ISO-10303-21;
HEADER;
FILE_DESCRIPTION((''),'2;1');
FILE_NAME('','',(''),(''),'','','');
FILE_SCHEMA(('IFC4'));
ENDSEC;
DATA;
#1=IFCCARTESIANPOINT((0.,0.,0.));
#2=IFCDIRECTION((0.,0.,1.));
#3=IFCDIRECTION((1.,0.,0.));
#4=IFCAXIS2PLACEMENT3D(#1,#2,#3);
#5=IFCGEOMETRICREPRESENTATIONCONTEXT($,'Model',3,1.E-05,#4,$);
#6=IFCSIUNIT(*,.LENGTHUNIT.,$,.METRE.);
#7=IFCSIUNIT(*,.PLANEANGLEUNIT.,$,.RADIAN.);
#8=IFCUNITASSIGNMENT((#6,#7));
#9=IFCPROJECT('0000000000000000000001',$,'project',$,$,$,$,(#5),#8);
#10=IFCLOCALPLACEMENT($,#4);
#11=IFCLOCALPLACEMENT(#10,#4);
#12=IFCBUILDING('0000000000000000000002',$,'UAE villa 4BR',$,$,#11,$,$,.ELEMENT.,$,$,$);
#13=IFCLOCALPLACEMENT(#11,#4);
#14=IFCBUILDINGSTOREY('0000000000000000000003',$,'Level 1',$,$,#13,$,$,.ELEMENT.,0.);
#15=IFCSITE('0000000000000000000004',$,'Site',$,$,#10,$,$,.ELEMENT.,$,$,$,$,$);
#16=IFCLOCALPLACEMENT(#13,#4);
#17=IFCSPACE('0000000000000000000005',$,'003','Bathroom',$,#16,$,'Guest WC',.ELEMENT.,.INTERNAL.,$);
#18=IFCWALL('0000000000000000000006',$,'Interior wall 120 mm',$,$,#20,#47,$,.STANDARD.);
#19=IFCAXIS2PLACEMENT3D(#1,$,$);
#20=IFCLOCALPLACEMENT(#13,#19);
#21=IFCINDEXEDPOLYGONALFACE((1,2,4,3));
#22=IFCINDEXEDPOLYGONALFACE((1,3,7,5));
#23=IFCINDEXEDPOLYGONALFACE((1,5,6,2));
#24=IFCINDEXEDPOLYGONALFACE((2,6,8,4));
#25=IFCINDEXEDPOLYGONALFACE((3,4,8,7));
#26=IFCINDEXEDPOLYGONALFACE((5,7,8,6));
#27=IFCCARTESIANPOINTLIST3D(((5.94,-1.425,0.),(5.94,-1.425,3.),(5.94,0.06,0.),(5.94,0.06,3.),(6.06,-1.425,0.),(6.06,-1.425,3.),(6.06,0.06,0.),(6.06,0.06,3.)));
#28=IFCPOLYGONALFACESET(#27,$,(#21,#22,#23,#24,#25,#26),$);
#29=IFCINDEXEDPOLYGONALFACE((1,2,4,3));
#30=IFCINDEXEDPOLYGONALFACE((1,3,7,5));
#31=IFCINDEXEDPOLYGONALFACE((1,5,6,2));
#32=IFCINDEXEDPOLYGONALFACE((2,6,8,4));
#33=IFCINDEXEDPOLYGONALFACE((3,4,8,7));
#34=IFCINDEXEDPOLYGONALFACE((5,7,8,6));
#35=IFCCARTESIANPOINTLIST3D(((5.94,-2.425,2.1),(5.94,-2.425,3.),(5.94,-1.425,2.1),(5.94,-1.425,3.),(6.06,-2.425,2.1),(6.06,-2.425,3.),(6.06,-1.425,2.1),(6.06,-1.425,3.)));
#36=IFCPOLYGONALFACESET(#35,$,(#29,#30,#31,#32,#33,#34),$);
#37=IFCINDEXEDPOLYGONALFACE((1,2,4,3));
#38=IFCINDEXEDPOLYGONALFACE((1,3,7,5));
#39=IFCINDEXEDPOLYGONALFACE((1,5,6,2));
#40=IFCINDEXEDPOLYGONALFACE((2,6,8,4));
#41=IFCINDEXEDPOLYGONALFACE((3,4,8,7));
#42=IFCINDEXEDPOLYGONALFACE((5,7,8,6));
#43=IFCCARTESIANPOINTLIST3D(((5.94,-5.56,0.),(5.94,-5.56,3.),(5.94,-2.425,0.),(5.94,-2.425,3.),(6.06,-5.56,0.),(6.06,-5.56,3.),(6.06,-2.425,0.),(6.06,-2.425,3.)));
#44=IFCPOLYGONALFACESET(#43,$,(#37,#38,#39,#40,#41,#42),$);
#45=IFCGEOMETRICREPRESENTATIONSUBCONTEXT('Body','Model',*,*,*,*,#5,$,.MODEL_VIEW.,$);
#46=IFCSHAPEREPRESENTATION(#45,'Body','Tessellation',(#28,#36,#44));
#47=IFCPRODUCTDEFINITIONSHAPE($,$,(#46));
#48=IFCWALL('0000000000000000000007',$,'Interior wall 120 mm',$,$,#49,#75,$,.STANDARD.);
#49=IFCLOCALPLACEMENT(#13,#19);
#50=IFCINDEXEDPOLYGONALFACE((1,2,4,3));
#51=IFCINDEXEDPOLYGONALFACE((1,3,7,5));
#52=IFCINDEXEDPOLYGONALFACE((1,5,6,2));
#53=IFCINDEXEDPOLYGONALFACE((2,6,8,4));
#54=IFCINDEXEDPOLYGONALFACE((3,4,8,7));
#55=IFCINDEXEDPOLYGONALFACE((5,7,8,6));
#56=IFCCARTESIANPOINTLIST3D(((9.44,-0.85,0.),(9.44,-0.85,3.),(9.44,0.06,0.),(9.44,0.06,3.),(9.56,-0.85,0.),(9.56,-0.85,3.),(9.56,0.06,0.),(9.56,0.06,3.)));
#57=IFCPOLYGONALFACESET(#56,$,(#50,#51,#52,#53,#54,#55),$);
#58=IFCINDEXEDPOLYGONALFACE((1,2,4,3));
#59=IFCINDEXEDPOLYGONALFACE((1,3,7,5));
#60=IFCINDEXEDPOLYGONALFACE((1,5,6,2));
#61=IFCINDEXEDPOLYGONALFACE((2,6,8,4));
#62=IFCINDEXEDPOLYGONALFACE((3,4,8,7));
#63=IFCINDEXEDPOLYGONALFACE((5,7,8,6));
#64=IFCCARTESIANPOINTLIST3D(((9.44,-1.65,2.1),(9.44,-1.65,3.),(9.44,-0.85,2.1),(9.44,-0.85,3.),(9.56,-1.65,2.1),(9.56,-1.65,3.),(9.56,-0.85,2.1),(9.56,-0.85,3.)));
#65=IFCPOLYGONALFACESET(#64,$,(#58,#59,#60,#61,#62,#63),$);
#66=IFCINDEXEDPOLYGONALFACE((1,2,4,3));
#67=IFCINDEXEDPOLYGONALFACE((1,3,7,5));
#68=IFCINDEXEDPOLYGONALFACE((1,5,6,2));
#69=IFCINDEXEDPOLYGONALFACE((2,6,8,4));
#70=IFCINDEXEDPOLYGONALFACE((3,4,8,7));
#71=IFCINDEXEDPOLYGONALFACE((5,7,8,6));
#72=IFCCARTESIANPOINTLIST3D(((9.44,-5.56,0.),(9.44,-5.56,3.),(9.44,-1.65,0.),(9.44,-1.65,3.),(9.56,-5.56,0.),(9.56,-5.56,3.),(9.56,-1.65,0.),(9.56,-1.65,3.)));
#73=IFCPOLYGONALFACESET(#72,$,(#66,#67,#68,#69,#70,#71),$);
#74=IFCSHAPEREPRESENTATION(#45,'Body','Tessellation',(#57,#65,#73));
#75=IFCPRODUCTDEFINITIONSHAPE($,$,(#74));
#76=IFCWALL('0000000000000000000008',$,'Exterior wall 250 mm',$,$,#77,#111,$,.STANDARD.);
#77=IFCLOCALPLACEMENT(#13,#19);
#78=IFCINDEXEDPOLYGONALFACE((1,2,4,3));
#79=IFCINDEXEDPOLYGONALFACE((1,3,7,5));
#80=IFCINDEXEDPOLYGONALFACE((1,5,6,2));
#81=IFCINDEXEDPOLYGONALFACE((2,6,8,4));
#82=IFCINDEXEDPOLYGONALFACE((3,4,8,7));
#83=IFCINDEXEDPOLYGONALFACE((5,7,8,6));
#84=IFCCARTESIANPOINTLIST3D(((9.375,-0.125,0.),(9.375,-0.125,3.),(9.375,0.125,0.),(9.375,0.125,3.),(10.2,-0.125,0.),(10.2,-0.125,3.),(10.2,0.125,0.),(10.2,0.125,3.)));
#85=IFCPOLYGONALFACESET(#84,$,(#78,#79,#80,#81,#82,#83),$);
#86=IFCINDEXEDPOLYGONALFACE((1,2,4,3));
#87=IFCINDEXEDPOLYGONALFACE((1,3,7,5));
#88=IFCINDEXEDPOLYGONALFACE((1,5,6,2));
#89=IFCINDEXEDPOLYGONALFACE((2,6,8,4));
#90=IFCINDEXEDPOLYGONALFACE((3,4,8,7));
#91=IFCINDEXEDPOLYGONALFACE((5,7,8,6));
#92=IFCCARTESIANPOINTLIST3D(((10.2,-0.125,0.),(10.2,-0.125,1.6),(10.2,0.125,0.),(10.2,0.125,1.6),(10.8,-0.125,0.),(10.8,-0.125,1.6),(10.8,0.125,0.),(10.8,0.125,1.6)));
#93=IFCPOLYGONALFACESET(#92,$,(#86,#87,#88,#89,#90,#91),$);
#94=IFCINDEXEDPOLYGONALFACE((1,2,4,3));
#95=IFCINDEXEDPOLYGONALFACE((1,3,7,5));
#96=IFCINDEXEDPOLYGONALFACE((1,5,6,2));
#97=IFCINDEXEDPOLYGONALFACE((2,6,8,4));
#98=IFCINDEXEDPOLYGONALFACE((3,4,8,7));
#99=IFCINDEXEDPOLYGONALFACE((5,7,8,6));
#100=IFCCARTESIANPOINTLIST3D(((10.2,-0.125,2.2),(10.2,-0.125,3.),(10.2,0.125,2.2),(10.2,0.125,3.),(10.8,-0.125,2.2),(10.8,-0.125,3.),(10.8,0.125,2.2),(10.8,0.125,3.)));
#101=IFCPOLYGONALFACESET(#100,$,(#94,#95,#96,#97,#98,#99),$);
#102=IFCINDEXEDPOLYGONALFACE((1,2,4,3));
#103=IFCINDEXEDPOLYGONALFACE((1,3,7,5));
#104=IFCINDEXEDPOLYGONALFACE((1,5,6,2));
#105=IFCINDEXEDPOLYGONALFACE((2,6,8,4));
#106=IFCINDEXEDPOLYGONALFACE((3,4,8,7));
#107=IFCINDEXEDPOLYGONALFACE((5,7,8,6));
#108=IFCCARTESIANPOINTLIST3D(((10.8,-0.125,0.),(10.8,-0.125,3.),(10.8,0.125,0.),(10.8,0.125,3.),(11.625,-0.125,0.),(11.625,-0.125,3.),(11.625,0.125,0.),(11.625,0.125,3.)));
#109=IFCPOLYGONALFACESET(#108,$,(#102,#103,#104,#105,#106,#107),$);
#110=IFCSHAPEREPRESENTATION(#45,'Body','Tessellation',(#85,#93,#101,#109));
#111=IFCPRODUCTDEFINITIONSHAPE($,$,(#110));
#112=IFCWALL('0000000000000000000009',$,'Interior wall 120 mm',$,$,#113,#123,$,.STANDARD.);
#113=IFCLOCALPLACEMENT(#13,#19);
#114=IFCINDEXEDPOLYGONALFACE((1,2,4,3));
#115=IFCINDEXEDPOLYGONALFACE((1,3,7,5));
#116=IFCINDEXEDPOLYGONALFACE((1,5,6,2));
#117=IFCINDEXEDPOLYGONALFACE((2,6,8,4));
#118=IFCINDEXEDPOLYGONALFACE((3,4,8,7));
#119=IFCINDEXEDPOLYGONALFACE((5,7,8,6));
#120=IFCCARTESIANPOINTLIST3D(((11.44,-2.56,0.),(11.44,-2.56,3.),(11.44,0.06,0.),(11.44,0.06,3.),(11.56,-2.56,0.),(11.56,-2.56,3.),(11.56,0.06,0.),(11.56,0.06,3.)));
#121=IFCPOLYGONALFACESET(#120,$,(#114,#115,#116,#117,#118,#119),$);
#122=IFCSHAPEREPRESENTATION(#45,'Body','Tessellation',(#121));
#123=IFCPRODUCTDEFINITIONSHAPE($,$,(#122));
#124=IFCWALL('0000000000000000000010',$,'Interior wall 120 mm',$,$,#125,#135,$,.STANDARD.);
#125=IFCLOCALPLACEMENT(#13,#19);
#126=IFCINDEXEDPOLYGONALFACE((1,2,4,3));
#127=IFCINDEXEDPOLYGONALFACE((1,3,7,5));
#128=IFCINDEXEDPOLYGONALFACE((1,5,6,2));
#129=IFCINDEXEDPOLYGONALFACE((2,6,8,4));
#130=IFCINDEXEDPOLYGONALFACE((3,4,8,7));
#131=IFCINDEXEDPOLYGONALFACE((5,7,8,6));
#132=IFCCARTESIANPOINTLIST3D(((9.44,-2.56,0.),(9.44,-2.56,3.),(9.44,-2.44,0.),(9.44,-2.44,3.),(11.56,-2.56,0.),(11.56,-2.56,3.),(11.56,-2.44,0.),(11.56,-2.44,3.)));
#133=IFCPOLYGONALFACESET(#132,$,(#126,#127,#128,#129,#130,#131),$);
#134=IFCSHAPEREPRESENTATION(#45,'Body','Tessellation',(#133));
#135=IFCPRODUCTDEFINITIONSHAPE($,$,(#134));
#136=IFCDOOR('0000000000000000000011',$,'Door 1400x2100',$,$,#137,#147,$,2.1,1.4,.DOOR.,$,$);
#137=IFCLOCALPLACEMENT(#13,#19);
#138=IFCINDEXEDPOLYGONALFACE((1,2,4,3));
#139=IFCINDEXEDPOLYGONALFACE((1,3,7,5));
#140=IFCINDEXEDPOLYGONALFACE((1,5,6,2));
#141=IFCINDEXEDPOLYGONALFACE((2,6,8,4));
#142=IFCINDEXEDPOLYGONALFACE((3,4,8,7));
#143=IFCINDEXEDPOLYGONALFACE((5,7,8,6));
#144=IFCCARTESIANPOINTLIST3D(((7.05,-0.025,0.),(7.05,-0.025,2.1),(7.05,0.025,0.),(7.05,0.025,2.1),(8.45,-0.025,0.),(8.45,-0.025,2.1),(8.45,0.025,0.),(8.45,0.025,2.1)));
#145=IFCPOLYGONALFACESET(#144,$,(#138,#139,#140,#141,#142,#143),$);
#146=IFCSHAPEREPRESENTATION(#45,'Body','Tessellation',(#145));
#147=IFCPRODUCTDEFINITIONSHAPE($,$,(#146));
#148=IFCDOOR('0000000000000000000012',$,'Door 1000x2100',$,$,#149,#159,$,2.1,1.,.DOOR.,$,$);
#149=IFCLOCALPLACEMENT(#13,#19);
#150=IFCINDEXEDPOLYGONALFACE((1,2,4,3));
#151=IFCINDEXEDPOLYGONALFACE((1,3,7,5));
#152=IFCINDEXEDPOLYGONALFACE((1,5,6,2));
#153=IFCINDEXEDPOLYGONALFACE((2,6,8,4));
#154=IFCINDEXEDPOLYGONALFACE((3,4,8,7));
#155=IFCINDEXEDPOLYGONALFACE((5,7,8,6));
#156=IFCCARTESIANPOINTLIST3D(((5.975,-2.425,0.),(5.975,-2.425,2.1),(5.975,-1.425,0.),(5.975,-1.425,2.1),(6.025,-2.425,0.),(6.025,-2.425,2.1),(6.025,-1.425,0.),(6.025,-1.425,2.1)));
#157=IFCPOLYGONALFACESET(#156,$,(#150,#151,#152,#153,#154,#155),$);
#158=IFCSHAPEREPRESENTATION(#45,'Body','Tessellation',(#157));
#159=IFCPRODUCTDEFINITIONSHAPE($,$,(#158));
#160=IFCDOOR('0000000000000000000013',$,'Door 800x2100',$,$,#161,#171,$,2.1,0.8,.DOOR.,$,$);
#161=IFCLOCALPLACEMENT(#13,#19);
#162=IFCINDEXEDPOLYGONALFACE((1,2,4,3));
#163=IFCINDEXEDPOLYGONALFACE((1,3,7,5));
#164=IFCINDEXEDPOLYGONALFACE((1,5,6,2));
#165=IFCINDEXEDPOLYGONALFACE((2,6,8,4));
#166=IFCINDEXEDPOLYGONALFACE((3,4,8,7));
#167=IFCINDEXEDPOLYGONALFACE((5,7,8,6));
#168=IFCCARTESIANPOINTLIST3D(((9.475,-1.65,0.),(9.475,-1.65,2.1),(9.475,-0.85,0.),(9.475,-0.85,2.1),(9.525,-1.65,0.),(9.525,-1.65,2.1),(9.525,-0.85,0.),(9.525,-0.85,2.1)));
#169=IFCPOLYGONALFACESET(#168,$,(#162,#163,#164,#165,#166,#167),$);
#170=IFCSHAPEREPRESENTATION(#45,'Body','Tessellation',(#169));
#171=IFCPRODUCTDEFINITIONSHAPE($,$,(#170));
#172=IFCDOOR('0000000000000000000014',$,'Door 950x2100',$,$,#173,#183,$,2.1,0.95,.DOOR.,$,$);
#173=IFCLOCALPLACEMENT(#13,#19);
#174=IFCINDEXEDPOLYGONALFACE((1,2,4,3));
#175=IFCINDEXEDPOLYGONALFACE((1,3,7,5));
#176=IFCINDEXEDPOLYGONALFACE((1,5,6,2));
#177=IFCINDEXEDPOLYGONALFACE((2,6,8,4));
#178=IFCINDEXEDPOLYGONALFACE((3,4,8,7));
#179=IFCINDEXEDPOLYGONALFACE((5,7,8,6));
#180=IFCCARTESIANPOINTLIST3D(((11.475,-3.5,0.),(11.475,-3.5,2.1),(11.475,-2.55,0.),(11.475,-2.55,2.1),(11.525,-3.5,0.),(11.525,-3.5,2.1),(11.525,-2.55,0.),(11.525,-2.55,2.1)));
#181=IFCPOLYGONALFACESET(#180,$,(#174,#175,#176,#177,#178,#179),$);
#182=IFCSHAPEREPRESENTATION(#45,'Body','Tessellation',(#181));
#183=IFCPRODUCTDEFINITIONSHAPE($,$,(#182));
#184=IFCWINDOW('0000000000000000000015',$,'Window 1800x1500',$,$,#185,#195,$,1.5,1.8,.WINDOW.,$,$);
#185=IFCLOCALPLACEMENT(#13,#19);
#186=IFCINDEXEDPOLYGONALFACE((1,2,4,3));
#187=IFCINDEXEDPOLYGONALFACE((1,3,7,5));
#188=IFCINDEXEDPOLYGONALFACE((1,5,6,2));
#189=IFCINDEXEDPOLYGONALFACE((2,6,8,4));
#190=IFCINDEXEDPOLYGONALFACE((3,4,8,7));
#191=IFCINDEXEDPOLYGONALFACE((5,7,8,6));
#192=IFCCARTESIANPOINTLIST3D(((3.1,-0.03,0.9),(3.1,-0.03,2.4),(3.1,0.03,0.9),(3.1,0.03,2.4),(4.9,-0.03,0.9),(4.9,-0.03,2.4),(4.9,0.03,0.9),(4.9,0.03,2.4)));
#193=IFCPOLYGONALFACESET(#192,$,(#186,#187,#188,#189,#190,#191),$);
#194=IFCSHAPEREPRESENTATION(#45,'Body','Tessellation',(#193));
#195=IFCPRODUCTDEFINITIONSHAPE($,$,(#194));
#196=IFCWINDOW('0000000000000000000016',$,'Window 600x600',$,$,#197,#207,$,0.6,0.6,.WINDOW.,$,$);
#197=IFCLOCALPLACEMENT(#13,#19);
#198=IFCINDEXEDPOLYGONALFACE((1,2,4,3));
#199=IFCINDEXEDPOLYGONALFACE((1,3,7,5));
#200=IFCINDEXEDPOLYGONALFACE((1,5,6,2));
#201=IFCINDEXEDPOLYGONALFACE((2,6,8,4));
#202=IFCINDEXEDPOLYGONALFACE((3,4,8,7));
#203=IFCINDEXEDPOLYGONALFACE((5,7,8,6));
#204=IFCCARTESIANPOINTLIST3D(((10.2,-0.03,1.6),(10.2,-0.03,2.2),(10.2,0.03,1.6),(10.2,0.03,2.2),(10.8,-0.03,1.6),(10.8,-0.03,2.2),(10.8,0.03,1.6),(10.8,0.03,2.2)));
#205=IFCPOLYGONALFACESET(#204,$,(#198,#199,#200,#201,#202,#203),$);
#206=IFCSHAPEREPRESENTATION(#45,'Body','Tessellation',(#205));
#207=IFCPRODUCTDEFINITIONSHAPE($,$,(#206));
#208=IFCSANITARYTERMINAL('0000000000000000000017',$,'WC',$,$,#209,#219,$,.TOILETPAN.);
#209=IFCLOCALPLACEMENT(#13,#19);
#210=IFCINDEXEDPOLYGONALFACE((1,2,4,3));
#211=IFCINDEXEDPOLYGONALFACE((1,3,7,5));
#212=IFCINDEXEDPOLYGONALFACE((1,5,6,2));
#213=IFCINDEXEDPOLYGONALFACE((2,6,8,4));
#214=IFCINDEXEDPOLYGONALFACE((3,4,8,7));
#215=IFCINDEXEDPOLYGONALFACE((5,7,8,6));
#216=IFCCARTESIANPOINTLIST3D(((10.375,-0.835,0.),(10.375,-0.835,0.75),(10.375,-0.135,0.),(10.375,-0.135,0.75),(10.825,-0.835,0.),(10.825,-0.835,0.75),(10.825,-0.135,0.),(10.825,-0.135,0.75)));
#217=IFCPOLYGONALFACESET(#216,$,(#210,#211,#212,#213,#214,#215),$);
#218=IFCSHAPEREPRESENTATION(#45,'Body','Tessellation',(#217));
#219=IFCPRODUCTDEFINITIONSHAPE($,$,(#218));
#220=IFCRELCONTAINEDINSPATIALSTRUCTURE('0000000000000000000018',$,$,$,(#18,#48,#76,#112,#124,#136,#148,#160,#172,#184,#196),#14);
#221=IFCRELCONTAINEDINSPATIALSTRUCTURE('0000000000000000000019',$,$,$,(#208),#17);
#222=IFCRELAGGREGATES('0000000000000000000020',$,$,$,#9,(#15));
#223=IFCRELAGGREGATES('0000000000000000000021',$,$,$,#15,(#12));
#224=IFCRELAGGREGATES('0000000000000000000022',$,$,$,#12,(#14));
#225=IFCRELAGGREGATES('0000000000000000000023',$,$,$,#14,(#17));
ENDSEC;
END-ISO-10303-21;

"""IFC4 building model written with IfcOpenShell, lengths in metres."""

from ifc_helpers import new_model, si_unit, frame, origin, origin_with_axes, origin_2d, place, context, subcontext, project, spatial, rectangle, extrude, element, save


model = new_model("IFC4")

# Units and contexts
model_context = context("Model", 3, precision=1e-05, world=origin_with_axes())
body_context = subcontext(model_context, "Body", "Model", "MODEL_VIEW")
ifc_project = project(units=[si_unit("LENGTHUNIT", "METRE"), si_unit("PLANEANGLEUNIT", "RADIAN")], contexts=[model_context])

# Site, building, storey
site_placement = place(None, origin_with_axes())
site = spatial("IfcSite", under=ifc_project, at=site_placement, Name="Site", CompositionType="ELEMENT")
building_placement = place(site_placement, origin_with_axes())
building = spatial("IfcBuilding", under=site, at=building_placement, Name="UAE villa 4BR", CompositionType="ELEMENT")
storey_placement = place(building_placement, origin_with_axes())
storey = spatial("IfcBuildingStorey", under=building, at=storey_placement, Name="Level 1", CompositionType="ELEMENT", Elevation=0.0)

# Walls
wall_1_placement = place(storey_placement, frame((6.0, 0.0, 0.0), z_axis=(0.0, 0.0, 1.0), x_axis=(0.0, -1.0, 0.0)))
element("IfcWall", 1, at=wall_1_placement, inside=storey, Name="Interior wall 120 mm", PredefinedType="STANDARD", context=body_context, shape_type="SweptSolid", body=[
    extrude(rectangle(XDim=1.485, YDim=0.12, at=origin_2d()), frame((0.6825, 0.0, 0.0)), (0.0, 0.0, 1.0), 3.0),
    extrude(rectangle(XDim=1.0, YDim=0.12, at=origin_2d()), frame((1.925, 0.0, 2.1)), (0.0, 0.0, 1.0), 0.9),
    extrude(rectangle(XDim=3.135, YDim=0.12, at=origin_2d()), frame((3.9925, 0.0, 0.0)), (0.0, 0.0, 1.0), 3.0),
])
wall_2_placement = place(storey_placement, frame((9.5, 0.0, 0.0), z_axis=(0.0, 0.0, 1.0), x_axis=(0.0, -1.0, 0.0)))
element("IfcWall", 2, at=wall_2_placement, inside=storey, Name="Interior wall 120 mm", PredefinedType="STANDARD", context=body_context, shape_type="SweptSolid", body=[
    extrude(rectangle(XDim=0.91, YDim=0.12, at=origin_2d()), frame((0.395, 0.0, 0.0)), (0.0, 0.0, 1.0), 3.0),
    extrude(rectangle(XDim=0.8, YDim=0.12, at=origin_2d()), frame((1.25, 0.0, 2.1)), (0.0, 0.0, 1.0), 0.9),
    extrude(rectangle(XDim=3.91, YDim=0.12, at=origin_2d()), frame((3.605, 0.0, 0.0)), (0.0, 0.0, 1.0), 3.0),
])
wall_3_placement = place(storey_placement, frame((9.5, 0.0, 0.0), z_axis=(0.0, 0.0, 1.0), x_axis=(1.0, 0.0, 0.0)))
element("IfcWall", 3, at=wall_3_placement, inside=storey, Name="Exterior wall 250 mm", PredefinedType="STANDARD", context=body_context, shape_type="SweptSolid", body=[
    extrude(rectangle(XDim=0.825, YDim=0.25, at=origin_2d()), frame((0.2875, 0.0, 0.0)), (0.0, 0.0, 1.0), 3.0),
    extrude(rectangle(XDim=0.6, YDim=0.25, at=origin_2d()), frame((1.0, 0.0, 0.0)), (0.0, 0.0, 1.0), 1.6),
    extrude(rectangle(XDim=0.6, YDim=0.25, at=origin_2d()), frame((1.0, 0.0, 2.2)), (0.0, 0.0, 1.0), 0.8),
    extrude(rectangle(XDim=0.825, YDim=0.25, at=origin_2d()), frame((1.7125, 0.0, 0.0)), (0.0, 0.0, 1.0), 3.0),
])
wall_4_placement = place(storey_placement, frame((11.5, 0.0, 0.0), z_axis=(0.0, 0.0, 1.0), x_axis=(0.0, -1.0, 0.0)))
element("IfcWall", 4, at=wall_4_placement, inside=storey, Name="Interior wall 120 mm", PredefinedType="STANDARD", context=body_context, shape_type="SweptSolid", body=[
    extrude(rectangle(XDim=2.62, YDim=0.12, at=origin_2d()), frame((1.25, 0.0, 0.0)), (0.0, 0.0, 1.0), 3.0),
])
wall_5_placement = place(storey_placement, frame((11.5, -2.5, 0.0), z_axis=(0.0, 0.0, 1.0), x_axis=(-1.0, 0.0, 0.0)))
element("IfcWall", 5, at=wall_5_placement, inside=storey, Name="Interior wall 120 mm", PredefinedType="STANDARD", context=body_context, shape_type="SweptSolid", body=[
    extrude(rectangle(XDim=2.12, YDim=0.12, at=origin_2d()), frame((1.0, 0.0, 0.0)), (0.0, 0.0, 1.0), 3.0),
])

# Doors
door_1_placement = place(storey_placement, frame((7.75, 0.0, 0.0), z_axis=(0.0, 0.0, 1.0), x_axis=(1.0, 0.0, 0.0)))
element("IfcDoor", 6, at=door_1_placement, inside=storey, Name="Door 1400x2100", OverallHeight=2.1, OverallWidth=1.4, PredefinedType="DOOR", context=body_context, shape_type="SweptSolid", body=[
    extrude(rectangle(XDim=1.4, YDim=0.05, at=origin_2d()), origin(), (0.0, 0.0, 1.0), 2.1),
])
door_2_placement = place(storey_placement, frame((6.0, -1.925, 0.0), z_axis=(0.0, 0.0, 1.0), x_axis=(0.0, -1.0, 0.0)))
element("IfcDoor", 7, at=door_2_placement, inside=storey, Name="Door 1000x2100", OverallHeight=2.1, OverallWidth=1.0, PredefinedType="DOOR", context=body_context, shape_type="SweptSolid", body=[
    extrude(rectangle(XDim=1.0, YDim=0.05, at=origin_2d()), origin(), (0.0, 0.0, 1.0), 2.1),
])
door_3_placement = place(storey_placement, frame((9.5, -1.25, 0.0), z_axis=(0.0, 0.0, 1.0), x_axis=(0.0, -1.0, 0.0)))
element("IfcDoor", 8, at=door_3_placement, inside=storey, Name="Door 800x2100", OverallHeight=2.1, OverallWidth=0.8, PredefinedType="DOOR", context=body_context, shape_type="SweptSolid", body=[
    extrude(rectangle(XDim=0.8, YDim=0.05, at=origin_2d()), origin(), (0.0, 0.0, 1.0), 2.1),
])
door_4_placement = place(storey_placement, frame((11.5, -3.025, 0.0), z_axis=(0.0, 0.0, 1.0), x_axis=(0.0, -1.0, 0.0)))
element("IfcDoor", 9, at=door_4_placement, inside=storey, Name="Door 950x2100", OverallHeight=2.1, OverallWidth=0.95, PredefinedType="DOOR", context=body_context, shape_type="SweptSolid", body=[
    extrude(rectangle(XDim=0.95, YDim=0.05, at=origin_2d()), origin(), (0.0, 0.0, 1.0), 2.1),
])

# Windows
window_1_placement = place(storey_placement, frame((4.0, 0.0, 0.9), z_axis=(0.0, 0.0, 1.0), x_axis=(1.0, 0.0, 0.0)))
element("IfcWindow", 10, at=window_1_placement, inside=storey, Name="Window 1800x1500", OverallHeight=1.5, OverallWidth=1.8, PredefinedType="WINDOW", context=body_context, shape_type="SweptSolid", body=[
    extrude(rectangle(XDim=1.8, YDim=0.06, at=origin_2d()), origin(), (0.0, 0.0, 1.0), 1.5),
])
window_2_placement = place(storey_placement, frame((10.5, 0.0, 1.6), z_axis=(0.0, 0.0, 1.0), x_axis=(1.0, 0.0, 0.0)))
element("IfcWindow", 11, at=window_2_placement, inside=storey, Name="Window 600x600", OverallHeight=0.6, OverallWidth=0.6, PredefinedType="WINDOW", context=body_context, shape_type="SweptSolid", body=[
    extrude(rectangle(XDim=0.6, YDim=0.06, at=origin_2d()), origin(), (0.0, 0.0, 1.0), 0.6),
])

# Shared definitions
space_1_placement = place(storey_placement, origin_with_axes())
space_1 = spatial("IfcSpace", under=storey, at=space_1_placement, Name="003", Description="Bathroom", LongName="Guest WC", CompositionType="ELEMENT", PredefinedType="INTERNAL")

# Sanitary terminal
sanitary_terminal_1_placement = place(storey_placement, frame((10.6, -0.485, 0.0), z_axis=(0.0, 0.0, 1.0), x_axis=(1.0, 0.0, 0.0)))
element("IfcSanitaryTerminal", 12, at=sanitary_terminal_1_placement, inside=space_1, Name="WC", PredefinedType="TOILETPAN", context=body_context, shape_type="SweptSolid", body=[
    extrude(rectangle(XDim=0.45, YDim=0.7, at=origin_2d()), origin(), (0.0, 0.0, 1.0), 0.75),
])

save(model, "model.ifc")
